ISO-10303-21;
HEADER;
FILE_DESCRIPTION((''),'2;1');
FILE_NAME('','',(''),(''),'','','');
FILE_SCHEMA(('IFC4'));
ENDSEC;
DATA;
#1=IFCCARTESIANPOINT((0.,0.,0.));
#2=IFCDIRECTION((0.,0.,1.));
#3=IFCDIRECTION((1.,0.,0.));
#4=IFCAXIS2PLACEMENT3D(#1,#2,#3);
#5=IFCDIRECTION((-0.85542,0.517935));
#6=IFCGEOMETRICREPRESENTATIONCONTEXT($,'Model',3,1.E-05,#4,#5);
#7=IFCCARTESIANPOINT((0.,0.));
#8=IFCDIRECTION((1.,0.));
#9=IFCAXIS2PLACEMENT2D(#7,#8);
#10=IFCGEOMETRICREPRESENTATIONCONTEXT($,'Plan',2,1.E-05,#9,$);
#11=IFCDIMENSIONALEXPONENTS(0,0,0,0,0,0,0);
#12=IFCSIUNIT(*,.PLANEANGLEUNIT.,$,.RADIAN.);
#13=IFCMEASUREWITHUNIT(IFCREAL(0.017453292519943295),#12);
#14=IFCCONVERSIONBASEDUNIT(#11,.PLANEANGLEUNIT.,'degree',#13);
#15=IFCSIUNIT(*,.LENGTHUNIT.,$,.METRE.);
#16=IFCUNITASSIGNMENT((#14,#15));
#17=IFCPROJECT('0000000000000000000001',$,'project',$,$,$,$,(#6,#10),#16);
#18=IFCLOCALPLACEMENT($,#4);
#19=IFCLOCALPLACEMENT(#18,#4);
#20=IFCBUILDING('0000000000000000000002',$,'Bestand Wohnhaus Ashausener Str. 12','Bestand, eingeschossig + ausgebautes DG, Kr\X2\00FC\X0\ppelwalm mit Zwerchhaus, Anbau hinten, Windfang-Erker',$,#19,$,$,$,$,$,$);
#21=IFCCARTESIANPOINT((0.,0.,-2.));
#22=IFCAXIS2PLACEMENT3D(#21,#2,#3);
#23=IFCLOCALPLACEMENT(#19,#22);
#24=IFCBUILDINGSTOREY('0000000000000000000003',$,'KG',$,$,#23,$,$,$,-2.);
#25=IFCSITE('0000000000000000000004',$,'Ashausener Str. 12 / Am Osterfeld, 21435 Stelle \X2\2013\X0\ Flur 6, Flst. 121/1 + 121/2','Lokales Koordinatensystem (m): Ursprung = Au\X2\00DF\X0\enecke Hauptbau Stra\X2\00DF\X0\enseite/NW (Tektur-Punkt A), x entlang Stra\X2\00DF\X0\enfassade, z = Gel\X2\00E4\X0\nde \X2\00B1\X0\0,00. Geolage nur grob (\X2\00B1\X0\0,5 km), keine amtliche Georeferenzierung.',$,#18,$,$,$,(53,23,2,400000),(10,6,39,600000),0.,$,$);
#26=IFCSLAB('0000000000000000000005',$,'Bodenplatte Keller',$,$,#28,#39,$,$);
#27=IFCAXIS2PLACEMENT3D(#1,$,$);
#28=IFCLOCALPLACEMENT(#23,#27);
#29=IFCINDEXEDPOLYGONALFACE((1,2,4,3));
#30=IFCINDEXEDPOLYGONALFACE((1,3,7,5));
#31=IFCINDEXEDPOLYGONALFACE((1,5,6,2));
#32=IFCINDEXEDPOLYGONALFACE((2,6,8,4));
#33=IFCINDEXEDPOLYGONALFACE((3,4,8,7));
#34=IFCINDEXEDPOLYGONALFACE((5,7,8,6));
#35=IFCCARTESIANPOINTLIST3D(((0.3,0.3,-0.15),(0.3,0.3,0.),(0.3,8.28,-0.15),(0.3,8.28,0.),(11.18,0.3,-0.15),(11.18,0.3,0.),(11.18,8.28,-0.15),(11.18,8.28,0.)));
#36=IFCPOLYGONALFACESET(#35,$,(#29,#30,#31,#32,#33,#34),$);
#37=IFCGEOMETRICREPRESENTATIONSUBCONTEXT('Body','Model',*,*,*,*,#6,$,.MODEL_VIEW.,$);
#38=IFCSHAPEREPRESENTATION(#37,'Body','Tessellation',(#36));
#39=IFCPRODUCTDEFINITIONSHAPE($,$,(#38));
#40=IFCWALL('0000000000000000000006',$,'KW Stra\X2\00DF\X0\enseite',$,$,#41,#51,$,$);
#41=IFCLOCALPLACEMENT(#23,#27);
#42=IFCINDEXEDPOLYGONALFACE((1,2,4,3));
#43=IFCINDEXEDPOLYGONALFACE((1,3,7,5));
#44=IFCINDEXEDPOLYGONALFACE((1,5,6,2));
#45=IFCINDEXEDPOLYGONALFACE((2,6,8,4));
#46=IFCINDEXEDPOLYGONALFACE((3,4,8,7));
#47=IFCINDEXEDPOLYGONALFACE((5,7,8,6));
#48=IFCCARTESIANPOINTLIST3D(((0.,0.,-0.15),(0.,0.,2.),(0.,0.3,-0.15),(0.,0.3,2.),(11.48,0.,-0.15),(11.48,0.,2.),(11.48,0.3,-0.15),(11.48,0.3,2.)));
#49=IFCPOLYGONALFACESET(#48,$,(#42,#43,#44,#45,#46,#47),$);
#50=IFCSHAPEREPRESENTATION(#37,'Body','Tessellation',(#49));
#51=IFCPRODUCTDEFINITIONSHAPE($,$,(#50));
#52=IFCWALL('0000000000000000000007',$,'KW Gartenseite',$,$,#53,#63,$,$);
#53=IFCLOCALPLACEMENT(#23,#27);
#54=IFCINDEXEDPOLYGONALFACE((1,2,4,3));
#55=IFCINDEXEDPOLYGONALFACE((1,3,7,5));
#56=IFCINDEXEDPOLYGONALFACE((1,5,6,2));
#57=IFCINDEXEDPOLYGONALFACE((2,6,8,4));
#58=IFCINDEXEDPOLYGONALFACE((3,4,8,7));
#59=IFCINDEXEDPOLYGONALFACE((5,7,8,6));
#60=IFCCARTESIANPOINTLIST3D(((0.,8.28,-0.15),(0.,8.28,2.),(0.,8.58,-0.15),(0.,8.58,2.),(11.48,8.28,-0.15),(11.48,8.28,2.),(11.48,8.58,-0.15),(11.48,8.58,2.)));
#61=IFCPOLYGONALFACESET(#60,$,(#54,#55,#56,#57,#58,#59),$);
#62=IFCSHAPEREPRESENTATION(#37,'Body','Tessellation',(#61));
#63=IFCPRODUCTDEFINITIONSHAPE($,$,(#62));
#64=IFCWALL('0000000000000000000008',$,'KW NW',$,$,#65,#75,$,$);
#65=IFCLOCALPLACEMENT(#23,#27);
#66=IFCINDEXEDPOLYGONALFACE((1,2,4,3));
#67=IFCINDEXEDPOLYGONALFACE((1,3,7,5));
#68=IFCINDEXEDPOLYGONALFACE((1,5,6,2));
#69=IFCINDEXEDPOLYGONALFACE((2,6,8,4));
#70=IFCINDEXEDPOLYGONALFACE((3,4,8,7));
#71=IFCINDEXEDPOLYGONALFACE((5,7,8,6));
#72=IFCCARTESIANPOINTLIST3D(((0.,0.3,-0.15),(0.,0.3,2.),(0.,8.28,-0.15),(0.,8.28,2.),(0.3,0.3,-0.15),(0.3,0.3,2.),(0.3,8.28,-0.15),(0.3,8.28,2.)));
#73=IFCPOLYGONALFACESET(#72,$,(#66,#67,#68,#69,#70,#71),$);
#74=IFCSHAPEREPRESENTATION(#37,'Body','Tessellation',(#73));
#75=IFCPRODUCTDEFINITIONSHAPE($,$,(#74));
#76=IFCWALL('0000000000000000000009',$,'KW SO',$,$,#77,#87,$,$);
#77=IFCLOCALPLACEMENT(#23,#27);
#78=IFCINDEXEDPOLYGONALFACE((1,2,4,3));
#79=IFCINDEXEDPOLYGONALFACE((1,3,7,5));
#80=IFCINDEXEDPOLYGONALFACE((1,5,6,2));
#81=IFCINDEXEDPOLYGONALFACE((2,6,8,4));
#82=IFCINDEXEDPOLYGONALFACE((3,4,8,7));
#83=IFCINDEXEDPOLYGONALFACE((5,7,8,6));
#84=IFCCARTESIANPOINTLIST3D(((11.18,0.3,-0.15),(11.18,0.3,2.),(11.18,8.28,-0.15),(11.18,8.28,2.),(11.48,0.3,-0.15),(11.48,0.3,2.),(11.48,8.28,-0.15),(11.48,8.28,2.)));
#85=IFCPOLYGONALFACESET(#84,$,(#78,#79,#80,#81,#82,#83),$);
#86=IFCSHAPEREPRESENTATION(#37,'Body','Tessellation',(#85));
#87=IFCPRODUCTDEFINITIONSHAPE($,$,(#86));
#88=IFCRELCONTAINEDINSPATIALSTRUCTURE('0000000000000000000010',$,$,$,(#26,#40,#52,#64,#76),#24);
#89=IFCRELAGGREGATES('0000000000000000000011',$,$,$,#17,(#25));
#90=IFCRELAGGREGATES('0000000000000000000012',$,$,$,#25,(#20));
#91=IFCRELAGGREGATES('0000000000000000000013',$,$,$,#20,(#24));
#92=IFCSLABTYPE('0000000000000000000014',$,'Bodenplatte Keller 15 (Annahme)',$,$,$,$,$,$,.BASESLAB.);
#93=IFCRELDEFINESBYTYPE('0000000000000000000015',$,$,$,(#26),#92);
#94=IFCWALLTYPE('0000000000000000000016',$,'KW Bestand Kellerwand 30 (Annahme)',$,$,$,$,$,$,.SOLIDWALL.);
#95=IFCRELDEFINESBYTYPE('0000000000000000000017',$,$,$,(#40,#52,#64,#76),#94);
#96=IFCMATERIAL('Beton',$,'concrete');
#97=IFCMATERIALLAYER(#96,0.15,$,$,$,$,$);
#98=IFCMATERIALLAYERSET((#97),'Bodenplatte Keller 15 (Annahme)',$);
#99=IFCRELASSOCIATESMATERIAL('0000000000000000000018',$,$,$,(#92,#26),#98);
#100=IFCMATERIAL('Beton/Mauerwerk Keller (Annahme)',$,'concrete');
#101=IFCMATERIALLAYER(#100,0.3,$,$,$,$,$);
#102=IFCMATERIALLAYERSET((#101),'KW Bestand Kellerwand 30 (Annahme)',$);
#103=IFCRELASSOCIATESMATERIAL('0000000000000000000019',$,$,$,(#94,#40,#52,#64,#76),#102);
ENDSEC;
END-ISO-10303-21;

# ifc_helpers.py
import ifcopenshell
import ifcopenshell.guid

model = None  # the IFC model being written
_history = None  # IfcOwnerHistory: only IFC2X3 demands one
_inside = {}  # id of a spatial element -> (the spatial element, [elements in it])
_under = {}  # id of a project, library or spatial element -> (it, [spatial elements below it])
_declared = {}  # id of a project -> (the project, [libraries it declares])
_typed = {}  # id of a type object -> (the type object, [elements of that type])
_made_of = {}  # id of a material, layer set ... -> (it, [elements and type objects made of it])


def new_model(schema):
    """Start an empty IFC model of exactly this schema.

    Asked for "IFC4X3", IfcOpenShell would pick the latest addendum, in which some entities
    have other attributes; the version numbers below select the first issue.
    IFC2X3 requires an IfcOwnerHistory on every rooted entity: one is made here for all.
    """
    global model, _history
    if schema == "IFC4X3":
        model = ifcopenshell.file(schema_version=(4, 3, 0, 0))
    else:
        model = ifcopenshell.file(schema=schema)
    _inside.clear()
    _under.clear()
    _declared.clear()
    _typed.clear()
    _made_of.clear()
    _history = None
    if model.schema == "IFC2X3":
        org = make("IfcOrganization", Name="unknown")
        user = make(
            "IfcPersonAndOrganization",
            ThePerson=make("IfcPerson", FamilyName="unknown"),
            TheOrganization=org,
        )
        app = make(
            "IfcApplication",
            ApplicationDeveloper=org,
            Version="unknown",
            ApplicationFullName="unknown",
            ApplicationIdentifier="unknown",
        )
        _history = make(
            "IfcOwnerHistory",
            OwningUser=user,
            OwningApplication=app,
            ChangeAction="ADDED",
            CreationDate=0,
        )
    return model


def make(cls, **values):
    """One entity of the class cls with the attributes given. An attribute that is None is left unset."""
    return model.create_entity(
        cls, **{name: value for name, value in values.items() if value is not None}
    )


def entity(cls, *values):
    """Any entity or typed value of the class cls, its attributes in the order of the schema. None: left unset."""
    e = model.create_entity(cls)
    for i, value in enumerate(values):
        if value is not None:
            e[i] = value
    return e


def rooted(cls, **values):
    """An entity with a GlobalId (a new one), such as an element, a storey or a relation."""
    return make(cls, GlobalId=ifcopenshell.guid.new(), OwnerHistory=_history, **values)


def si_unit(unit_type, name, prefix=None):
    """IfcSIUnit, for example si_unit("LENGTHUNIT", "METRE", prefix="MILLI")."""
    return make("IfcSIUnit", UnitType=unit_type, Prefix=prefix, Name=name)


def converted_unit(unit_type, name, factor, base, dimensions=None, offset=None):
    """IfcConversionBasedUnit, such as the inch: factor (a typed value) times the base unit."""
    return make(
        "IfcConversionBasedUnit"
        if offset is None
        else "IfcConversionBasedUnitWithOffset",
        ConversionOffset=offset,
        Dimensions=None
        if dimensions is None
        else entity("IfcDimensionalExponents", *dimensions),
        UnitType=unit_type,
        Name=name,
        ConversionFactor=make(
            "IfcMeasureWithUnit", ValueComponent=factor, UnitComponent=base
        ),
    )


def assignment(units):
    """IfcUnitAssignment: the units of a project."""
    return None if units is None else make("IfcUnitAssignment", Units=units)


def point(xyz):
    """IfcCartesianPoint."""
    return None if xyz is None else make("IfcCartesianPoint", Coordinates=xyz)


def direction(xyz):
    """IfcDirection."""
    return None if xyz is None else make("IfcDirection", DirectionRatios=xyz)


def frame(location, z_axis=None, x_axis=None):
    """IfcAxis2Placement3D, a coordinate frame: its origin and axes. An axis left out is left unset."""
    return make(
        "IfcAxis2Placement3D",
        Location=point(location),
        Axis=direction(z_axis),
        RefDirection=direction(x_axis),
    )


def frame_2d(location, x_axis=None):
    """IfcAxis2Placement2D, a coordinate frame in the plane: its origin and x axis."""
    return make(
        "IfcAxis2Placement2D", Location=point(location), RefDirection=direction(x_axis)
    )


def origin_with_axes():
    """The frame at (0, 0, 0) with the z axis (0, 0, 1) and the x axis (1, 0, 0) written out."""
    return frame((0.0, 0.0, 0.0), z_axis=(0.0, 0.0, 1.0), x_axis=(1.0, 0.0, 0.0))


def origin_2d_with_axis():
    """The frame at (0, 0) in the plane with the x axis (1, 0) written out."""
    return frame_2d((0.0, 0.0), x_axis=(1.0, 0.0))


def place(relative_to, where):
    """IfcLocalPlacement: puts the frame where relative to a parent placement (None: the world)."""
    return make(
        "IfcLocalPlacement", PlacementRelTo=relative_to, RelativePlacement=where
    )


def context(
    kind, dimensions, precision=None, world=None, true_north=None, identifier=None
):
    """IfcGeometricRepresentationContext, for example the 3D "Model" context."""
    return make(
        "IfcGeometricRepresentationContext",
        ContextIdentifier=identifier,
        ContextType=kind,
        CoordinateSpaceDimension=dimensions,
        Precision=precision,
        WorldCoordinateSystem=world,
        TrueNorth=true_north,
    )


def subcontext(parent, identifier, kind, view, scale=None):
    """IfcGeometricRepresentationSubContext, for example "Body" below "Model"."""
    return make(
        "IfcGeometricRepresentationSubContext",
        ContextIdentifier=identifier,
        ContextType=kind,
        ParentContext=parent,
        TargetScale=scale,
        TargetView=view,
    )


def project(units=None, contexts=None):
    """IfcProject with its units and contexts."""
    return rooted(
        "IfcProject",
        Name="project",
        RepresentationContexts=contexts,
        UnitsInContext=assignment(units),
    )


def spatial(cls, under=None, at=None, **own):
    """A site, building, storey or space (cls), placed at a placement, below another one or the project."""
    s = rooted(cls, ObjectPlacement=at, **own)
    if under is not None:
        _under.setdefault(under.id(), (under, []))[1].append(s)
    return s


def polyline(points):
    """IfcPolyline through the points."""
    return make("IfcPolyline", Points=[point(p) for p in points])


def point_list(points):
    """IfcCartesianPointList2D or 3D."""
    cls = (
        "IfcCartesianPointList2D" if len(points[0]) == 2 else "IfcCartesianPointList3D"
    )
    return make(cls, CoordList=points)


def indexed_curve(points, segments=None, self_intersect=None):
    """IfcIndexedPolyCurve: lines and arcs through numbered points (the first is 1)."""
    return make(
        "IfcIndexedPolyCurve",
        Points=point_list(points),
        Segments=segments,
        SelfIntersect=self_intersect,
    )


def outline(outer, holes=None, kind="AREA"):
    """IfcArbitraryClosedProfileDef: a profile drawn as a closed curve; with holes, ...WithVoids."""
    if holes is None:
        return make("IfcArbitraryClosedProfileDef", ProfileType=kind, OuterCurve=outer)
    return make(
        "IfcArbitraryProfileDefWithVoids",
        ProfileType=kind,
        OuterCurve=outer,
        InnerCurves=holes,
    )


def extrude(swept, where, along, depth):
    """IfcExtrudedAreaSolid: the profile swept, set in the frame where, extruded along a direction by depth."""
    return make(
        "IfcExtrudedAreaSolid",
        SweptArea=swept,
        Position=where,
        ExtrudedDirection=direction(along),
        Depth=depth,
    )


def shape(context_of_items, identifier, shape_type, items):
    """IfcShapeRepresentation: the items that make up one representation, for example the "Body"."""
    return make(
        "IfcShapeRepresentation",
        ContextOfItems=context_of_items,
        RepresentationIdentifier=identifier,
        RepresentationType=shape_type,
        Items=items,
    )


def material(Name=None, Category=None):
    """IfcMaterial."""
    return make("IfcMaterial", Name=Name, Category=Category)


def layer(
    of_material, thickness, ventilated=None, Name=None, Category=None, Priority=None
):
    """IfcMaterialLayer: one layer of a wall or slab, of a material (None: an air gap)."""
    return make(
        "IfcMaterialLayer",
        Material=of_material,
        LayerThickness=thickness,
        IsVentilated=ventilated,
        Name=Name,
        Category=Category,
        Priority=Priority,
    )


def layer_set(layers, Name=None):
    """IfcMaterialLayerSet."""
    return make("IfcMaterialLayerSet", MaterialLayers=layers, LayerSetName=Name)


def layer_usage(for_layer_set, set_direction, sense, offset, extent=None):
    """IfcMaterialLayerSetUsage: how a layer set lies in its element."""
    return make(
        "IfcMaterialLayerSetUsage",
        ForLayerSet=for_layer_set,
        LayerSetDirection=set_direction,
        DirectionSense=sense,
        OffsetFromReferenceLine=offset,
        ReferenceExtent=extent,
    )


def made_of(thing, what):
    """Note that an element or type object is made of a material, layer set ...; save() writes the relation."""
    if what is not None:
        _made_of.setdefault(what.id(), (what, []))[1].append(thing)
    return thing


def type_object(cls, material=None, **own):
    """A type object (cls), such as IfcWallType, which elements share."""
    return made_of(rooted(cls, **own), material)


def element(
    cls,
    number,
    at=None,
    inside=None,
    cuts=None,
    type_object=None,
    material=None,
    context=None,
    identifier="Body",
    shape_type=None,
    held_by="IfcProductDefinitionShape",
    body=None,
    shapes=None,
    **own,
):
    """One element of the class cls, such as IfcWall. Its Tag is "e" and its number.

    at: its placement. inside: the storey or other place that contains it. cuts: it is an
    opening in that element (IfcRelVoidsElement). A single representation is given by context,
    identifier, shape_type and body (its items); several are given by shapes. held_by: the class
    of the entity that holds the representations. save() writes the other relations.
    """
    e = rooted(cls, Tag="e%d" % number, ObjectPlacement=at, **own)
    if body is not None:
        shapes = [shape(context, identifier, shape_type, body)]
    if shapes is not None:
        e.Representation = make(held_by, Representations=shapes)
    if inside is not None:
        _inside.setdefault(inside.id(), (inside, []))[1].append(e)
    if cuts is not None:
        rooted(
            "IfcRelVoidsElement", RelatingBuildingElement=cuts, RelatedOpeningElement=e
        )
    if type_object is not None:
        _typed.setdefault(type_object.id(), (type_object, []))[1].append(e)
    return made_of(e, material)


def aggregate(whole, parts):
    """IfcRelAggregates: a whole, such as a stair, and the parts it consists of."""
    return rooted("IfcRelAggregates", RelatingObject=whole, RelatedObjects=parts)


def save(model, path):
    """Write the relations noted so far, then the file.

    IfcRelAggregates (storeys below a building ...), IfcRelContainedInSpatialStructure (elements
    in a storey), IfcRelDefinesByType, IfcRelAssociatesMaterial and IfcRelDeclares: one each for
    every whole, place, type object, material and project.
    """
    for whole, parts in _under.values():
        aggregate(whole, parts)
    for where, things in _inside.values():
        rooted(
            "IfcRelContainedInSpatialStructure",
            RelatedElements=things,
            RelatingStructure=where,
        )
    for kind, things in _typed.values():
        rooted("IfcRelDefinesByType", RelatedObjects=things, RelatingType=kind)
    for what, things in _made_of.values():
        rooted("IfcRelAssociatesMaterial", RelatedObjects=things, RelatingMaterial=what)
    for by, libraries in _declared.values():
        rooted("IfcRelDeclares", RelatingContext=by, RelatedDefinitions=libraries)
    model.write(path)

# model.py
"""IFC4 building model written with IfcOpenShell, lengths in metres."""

from ifc_helpers import new_model, entity, si_unit, converted_unit, direction, frame, origin_with_axes, origin_2d_with_axis, place, context, subcontext, project, spatial, polyline, indexed_curve, outline, extrude, material, layer, layer_set, layer_usage, type_object, element, save


model = new_model("IFC4")

# Units and contexts
model_context = context("Model", 3, precision=1e-05, world=origin_with_axes(), true_north=direction((-0.85542, 0.517935)))
plan_context = context("Plan", 2, precision=1e-05, world=origin_2d_with_axis())
body_context = subcontext(model_context, "Body", "Model", "MODEL_VIEW")
ifc_project = project(units=[converted_unit("PLANEANGLEUNIT", "degree", entity("IfcReal", 0.017453292519943295), si_unit("PLANEANGLEUNIT", "RADIAN"), dimensions=[0, 0, 0, 0, 0, 0, 0]), si_unit("LENGTHUNIT", "METRE")], contexts=[model_context, plan_context])

# Site, building, storey
site_placement = place(None, origin_with_axes())
site = spatial("IfcSite", under=ifc_project, at=site_placement, Name="Ashausener Str. 12 / Am Osterfeld, 21435 Stelle – Flur 6, Flst. 121/1 + 121/2", Description="Lokales Koordinatensystem (m): Ursprung = Außenecke Hauptbau Straßenseite/NW (Tektur-Punkt A), x entlang Straßenfassade, z = Gelände ±0,00. Geolage nur grob (±0,5 km), keine amtliche Georeferenzierung.", RefLatitude=(53, 23, 2, 400000), RefLongitude=(10, 6, 39, 600000), RefElevation=0.0)
building_placement = place(site_placement, origin_with_axes())
building = spatial("IfcBuilding", under=site, at=building_placement, Name="Bestand Wohnhaus Ashausener Str. 12", Description="Bestand, eingeschossig + ausgebautes DG, Krüppelwalm mit Zwerchhaus, Anbau hinten, Windfang-Erker")
storey_placement = place(building_placement, frame((0.0, 0.0, -2.0), z_axis=(0.0, 0.0, 1.0), x_axis=(1.0, 0.0, 0.0)))
storey = spatial("IfcBuildingStorey", under=building, at=storey_placement, Name="KG", Elevation=-2.0)

# Slab
ifc_material_1 = material(Name="Beton", Category="concrete")
ifc_layer_1 = layer(ifc_material_1, 0.15)
ifc_layer_set_1 = layer_set([ifc_layer_1], Name="Bodenplatte Keller 15 (Annahme)")
ifc_layer_usage_1 = layer_usage(ifc_layer_set_1, "AXIS3", "POSITIVE", 0.0)
slab_type = type_object("IfcSlabType", Name="Bodenplatte Keller 15 (Annahme)", PredefinedType="BASESLAB", material=ifc_layer_set_1)
slab_placement = place(storey_placement, frame((0.0, 0.0, 2.0), z_axis=(0.0, 0.0, 1.0), x_axis=(1.0, 0.0, 0.0)))
element("IfcSlab", 1, at=slab_placement, inside=storey, type_object=slab_type, material=ifc_layer_usage_1, Name="Bodenplatte Keller", context=body_context, shape_type="SweptSolid", body=[
    extrude(outline(polyline([(0.3, 0.3), (11.18, 0.3), (11.18, 8.28), (0.3, 8.28), (0.3, 0.3)])), frame((0.0, 0.0, -2.15)), (0.0, 0.0, 1.0), 0.15),
])

# Walls
ifc_material_2 = material(Name="Beton/Mauerwerk Keller (Annahme)", Category="concrete")
ifc_layer_2 = layer(ifc_material_2, 0.3)
ifc_layer_set_2 = layer_set([ifc_layer_2], Name="KW Bestand Kellerwand 30 (Annahme)")
ifc_layer_usage_2 = layer_usage(ifc_layer_set_2, "AXIS2", "POSITIVE", 0.0)
wall_type = type_object("IfcWallType", Name="KW Bestand Kellerwand 30 (Annahme)", PredefinedType="SOLIDWALL", material=ifc_layer_set_2)
wall_1_placement = place(storey_placement, frame((0.0, 0.0, -0.15), z_axis=(0.0, 0.0, 1.0), x_axis=(1.0, 0.0, 0.0)))
element("IfcWall", 2, at=wall_1_placement, inside=storey, type_object=wall_type, material=ifc_layer_usage_2, Name="KW Straßenseite", context=body_context, shape_type="SweptSolid", body=[
    extrude(outline(indexed_curve([(0.0, 0.0), (0.0, 0.3), (11.48, 0.3), (11.48, 0.0), (0.0, 0.0)], self_intersect=False)), origin_with_axes(), (0.0, 0.0, 1.0), 2.15),
])
ifc_layer_usage_3 = layer_usage(ifc_layer_set_2, "AXIS2", "POSITIVE", 0.0)
wall_2_placement = place(storey_placement, frame((11.48, 8.58, -0.15), z_axis=(0.0, 0.0, 1.0), x_axis=(-1.0, 0.0, 0.0)))
element("IfcWall", 3, at=wall_2_placement, inside=storey, type_object=wall_type, material=ifc_layer_usage_3, Name="KW Gartenseite", context=body_context, shape_type="SweptSolid", body=[
    extrude(outline(indexed_curve([(0.0, 0.0), (0.0, 0.3), (11.48, 0.3), (11.48, 0.0), (0.0, 0.0)], self_intersect=False)), origin_with_axes(), (0.0, 0.0, 1.0), 2.15),
])
ifc_layer_usage_4 = layer_usage(ifc_layer_set_2, "AXIS2", "POSITIVE", 0.0)
wall_3_placement = place(storey_placement, frame((0.0, 8.28, -0.15), z_axis=(0.0, 0.0, 1.0), x_axis=(0.0, -1.0, 0.0)))
element("IfcWall", 4, at=wall_3_placement, inside=storey, type_object=wall_type, material=ifc_layer_usage_4, Name="KW NW", context=body_context, shape_type="SweptSolid", body=[
    extrude(outline(indexed_curve([(0.0, 0.0), (0.0, 0.3), (7.98, 0.3), (7.98, 0.0), (0.0, 0.0)], self_intersect=False)), origin_with_axes(), (0.0, 0.0, 1.0), 2.15),
])
ifc_layer_usage_5 = layer_usage(ifc_layer_set_2, "AXIS2", "POSITIVE", 0.0)
wall_4_placement = place(storey_placement, frame((11.48, 0.3, -0.15), z_axis=(0.0, 0.0, 1.0), x_axis=(0.0, 1.0, 0.0)))
element("IfcWall", 5, at=wall_4_placement, inside=storey, type_object=wall_type, material=ifc_layer_usage_5, Name="KW SO", context=body_context, shape_type="SweptSolid", body=[
    extrude(outline(indexed_curve([(0.0, 0.0), (0.0, 0.3), (7.98, 0.3), (7.98, 0.0), (0.0, 0.0)], self_intersect=False)), origin_with_axes(), (0.0, 0.0, 1.0), 2.15),
])

save(model, "model.ifc")
